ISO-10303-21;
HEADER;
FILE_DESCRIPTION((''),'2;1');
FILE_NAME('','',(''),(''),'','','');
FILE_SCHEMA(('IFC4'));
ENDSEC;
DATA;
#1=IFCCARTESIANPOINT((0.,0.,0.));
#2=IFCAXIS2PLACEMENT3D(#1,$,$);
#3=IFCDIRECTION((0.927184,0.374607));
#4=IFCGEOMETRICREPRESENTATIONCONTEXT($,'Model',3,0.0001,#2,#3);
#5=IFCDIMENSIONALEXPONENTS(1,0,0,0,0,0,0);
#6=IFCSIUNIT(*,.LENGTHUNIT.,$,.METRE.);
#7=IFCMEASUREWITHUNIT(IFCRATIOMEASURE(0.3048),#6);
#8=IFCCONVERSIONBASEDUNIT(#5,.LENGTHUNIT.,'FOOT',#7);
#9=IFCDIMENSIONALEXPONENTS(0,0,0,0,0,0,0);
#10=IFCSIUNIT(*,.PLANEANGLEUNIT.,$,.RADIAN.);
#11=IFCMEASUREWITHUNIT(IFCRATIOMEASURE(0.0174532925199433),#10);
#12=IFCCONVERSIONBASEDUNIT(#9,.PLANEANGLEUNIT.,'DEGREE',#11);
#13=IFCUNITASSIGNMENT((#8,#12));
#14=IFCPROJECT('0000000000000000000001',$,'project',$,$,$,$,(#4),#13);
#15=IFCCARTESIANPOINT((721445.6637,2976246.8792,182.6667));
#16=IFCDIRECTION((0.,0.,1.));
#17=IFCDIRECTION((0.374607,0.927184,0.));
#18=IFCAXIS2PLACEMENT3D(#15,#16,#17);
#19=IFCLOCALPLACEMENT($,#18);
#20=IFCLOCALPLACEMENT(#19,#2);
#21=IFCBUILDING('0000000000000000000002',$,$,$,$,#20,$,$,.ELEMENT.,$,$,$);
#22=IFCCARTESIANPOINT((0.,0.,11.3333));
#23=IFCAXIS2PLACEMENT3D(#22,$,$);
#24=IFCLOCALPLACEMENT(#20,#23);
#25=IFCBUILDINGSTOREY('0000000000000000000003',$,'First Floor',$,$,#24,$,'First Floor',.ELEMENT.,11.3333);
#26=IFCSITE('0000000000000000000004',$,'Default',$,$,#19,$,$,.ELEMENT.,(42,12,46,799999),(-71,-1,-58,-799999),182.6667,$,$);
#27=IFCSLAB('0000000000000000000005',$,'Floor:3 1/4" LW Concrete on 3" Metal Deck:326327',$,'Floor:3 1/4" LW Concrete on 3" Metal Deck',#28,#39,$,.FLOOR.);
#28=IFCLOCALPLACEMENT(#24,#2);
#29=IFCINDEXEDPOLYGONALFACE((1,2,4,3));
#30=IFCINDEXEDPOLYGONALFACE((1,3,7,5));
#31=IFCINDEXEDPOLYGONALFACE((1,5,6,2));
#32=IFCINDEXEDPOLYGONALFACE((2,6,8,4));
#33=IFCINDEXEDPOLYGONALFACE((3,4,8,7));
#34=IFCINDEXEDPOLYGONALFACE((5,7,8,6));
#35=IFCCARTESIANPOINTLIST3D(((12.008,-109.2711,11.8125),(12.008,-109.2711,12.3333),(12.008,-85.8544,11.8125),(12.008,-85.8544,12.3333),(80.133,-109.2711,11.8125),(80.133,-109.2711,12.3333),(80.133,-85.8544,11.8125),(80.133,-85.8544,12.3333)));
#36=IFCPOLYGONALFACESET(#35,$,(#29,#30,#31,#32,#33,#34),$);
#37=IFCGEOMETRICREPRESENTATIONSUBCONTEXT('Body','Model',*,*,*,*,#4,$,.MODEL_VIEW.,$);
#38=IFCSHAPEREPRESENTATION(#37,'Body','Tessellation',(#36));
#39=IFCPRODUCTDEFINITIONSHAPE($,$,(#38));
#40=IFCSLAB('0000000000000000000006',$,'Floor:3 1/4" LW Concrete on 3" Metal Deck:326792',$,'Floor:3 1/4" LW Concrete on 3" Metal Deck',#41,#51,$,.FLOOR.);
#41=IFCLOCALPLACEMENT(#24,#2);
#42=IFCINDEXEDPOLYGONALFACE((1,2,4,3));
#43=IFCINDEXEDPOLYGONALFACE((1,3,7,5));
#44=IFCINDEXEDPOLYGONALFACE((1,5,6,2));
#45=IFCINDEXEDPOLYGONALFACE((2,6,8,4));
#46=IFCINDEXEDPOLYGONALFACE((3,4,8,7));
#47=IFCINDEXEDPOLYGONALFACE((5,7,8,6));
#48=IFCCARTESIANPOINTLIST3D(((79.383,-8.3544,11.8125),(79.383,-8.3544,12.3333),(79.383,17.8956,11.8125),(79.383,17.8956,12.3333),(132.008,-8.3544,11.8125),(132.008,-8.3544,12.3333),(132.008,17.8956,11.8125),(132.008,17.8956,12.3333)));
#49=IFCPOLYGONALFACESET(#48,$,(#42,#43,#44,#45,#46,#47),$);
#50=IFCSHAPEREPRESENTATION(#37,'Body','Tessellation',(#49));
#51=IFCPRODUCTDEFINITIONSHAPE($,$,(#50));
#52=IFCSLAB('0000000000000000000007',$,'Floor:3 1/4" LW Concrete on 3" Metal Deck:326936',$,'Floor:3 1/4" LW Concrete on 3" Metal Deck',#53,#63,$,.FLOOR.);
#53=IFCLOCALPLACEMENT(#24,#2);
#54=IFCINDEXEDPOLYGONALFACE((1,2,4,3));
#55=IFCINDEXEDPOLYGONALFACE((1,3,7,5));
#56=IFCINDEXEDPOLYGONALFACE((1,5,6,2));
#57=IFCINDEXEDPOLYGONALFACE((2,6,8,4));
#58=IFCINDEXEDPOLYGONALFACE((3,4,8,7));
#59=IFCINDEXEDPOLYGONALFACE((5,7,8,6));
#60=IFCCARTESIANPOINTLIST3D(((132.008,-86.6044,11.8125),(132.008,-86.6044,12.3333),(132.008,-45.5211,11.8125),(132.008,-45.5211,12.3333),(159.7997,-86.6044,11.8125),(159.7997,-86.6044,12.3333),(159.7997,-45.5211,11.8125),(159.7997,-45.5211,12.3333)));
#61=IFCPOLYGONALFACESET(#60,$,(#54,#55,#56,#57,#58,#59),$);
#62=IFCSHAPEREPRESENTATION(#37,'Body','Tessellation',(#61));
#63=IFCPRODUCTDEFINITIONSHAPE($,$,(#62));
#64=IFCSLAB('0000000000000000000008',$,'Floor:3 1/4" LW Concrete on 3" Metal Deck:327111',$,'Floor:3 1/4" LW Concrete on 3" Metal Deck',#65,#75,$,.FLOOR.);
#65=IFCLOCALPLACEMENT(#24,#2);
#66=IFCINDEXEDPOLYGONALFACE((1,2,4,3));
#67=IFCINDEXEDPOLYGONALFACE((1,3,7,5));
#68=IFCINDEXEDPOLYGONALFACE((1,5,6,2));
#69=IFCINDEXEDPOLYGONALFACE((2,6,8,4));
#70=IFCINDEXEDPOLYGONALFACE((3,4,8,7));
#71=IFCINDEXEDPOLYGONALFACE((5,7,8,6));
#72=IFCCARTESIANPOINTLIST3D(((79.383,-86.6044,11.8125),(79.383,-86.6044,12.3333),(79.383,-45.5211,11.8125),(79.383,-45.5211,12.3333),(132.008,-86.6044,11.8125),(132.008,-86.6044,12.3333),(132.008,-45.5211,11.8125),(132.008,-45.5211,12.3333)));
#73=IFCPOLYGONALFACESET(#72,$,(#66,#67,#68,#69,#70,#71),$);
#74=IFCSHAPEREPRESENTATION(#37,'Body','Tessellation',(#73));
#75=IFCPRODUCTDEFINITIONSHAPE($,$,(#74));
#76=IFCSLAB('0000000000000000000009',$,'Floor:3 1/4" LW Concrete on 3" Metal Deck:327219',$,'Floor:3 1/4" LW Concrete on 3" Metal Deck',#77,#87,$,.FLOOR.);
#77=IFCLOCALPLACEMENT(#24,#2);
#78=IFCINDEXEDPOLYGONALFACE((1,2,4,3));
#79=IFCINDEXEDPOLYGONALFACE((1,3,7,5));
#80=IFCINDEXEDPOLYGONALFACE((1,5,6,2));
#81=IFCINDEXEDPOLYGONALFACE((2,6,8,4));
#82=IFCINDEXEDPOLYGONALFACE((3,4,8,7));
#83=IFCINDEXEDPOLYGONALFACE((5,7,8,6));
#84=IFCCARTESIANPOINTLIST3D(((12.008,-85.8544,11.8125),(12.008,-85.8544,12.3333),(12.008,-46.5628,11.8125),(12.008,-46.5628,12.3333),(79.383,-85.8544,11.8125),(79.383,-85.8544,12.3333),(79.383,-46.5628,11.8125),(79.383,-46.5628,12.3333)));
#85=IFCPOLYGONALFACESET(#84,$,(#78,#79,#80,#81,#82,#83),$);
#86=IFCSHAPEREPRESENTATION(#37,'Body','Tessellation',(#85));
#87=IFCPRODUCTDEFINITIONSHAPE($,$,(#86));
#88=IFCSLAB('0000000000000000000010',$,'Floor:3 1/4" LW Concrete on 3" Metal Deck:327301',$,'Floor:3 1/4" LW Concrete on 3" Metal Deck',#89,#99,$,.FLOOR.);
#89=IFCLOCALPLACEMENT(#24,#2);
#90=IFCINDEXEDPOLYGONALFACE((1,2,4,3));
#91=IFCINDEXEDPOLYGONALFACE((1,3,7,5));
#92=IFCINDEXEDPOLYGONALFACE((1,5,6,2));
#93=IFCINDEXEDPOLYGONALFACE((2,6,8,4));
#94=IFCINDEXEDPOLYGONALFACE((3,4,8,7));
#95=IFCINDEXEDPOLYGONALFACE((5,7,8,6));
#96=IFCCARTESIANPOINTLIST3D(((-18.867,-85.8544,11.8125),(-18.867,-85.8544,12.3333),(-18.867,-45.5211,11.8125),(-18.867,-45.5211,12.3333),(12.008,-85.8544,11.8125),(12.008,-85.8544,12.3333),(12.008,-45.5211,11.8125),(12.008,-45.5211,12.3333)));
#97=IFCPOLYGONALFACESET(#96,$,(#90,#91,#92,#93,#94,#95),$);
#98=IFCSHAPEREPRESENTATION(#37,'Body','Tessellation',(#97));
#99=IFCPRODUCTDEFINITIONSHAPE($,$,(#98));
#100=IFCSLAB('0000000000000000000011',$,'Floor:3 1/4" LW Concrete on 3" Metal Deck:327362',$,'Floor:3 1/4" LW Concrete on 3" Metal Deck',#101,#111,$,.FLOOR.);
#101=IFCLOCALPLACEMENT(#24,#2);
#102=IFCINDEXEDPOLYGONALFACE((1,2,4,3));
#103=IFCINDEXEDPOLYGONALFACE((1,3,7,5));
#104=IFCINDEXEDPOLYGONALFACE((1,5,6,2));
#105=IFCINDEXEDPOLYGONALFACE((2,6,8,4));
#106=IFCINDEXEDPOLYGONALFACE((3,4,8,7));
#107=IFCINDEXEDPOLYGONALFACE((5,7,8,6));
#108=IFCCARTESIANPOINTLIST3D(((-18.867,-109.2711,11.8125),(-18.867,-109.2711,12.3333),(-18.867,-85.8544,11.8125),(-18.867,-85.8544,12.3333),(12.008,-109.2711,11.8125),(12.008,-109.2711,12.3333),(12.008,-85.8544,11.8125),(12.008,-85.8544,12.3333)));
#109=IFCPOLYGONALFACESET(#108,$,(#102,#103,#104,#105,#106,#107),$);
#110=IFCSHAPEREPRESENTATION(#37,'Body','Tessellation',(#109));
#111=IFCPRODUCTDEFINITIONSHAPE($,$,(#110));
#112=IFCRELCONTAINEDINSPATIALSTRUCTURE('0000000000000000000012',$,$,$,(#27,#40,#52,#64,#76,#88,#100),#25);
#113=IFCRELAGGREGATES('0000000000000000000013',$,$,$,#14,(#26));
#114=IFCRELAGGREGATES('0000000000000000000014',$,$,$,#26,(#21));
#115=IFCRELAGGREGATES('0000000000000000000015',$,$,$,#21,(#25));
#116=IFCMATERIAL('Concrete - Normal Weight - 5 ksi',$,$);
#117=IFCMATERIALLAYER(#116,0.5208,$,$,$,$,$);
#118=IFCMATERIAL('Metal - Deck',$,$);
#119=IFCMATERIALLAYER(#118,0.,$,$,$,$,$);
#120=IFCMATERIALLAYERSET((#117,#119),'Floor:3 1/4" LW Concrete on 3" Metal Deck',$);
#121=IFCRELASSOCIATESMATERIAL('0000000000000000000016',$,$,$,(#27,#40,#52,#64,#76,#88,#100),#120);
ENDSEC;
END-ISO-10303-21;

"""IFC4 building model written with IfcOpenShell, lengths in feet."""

from ifc_helpers import new_model, entity, si_unit, converted_unit, direction, frame, frame_2d, origin, place, context, subcontext, project, spatial, rectangle, extrude, material, layer, layer_set, layer_usage, element, save


model = new_model("IFC4")

# Units and contexts
model_context = context("Model", 3, precision=0.0001, world=origin(), true_north=direction((0.927184, 0.374607)))
body_context = subcontext(model_context, "Body", "Model", "MODEL_VIEW")
ifc_project = project(units=[converted_unit("LENGTHUNIT", "FOOT", entity("IfcRatioMeasure", 0.3048), si_unit("LENGTHUNIT", "METRE"), dimensions=[1, 0, 0, 0, 0, 0, 0]), converted_unit("PLANEANGLEUNIT", "DEGREE", entity("IfcRatioMeasure", 0.0174532925199433), si_unit("PLANEANGLEUNIT", "RADIAN"), dimensions=[0, 0, 0, 0, 0, 0, 0])], contexts=[model_context])

# Site, building, storey
site_placement = place(None, frame((721445.6637, 2976246.8792, 182.6667), z_axis=(0.0, 0.0, 1.0), x_axis=(0.374607, 0.927184, 0.0)))
site = spatial("IfcSite", under=ifc_project, at=site_placement, Name="Default", CompositionType="ELEMENT", RefLatitude=(42, 12, 46, 799999), RefLongitude=(-71, -1, -58, -799999), RefElevation=182.6667)
building_placement = place(site_placement, origin())
building = spatial("IfcBuilding", under=site, at=building_placement, CompositionType="ELEMENT")
storey_placement = place(building_placement, frame((0.0, 0.0, 11.3333)))
storey = spatial("IfcBuildingStorey", under=building, at=storey_placement, Name="First Floor", LongName="First Floor", CompositionType="ELEMENT", Elevation=11.3333)

# Slabs
ifc_material_1 = material(Name="Concrete - Normal Weight - 5 ksi")
ifc_layer_1 = layer(ifc_material_1, 0.5208)
ifc_material_2 = material(Name="Metal - Deck")
ifc_layer_2 = layer(ifc_material_2, 0.0)
ifc_layer_set = layer_set([ifc_layer_1, ifc_layer_2], Name="Floor:3 1/4\" LW Concrete on 3\" Metal Deck")
ifc_layer_usage_1 = layer_usage(ifc_layer_set, "AXIS3", "POSITIVE", 0.0)
slab_1_placement = place(storey_placement, origin())
element("IfcSlab", 1, at=slab_1_placement, inside=storey, material=ifc_layer_usage_1, Name="Floor:3 1/4\" LW Concrete on 3\" Metal Deck:326327", ObjectType="Floor:3 1/4\" LW Concrete on 3\" Metal Deck", PredefinedType="FLOOR", context=body_context, shape_type="SweptSolid", body=[
    extrude(rectangle(XDim=23.4167, YDim=68.125, at=frame_2d((0.0, 0.0), x_axis=(1.0, 0.0))), frame((46.0705, -97.5628, 12.3333), z_axis=(0.0, 0.0, -1.0), x_axis=(0.0, 1.0, 0.0)), (0.0, 0.0, 1.0), 0.5208),
])
ifc_layer_usage_2 = layer_usage(ifc_layer_set, "AXIS3", "POSITIVE", 0.0)
slab_2_placement = place(storey_placement, origin())
element("IfcSlab", 2, at=slab_2_placement, inside=storey, material=ifc_layer_usage_2, Name="Floor:3 1/4\" LW Concrete on 3\" Metal Deck:326792", ObjectType="Floor:3 1/4\" LW Concrete on 3\" Metal Deck", PredefinedType="FLOOR", context=body_context, shape_type="SweptSolid", body=[
    extrude(rectangle(XDim=26.25, YDim=52.625, at=frame_2d((0.0, 0.0), x_axis=(1.0, 0.0))), frame((105.6955, 4.7706, 12.3333), z_axis=(0.0, 0.0, -1.0), x_axis=(0.0, 1.0, 0.0)), (0.0, 0.0, 1.0), 0.5208),
])
ifc_layer_usage_3 = layer_usage(ifc_layer_set, "AXIS3", "POSITIVE", 0.0)
slab_3_placement = place(storey_placement, origin())
element("IfcSlab", 3, at=slab_3_placement, inside=storey, material=ifc_layer_usage_3, Name="Floor:3 1/4\" LW Concrete on 3\" Metal Deck:326936", ObjectType="Floor:3 1/4\" LW Concrete on 3\" Metal Deck", PredefinedType="FLOOR", context=body_context, shape_type="SweptSolid", body=[
    extrude(rectangle(XDim=41.0833, YDim=27.7917, at=frame_2d((0.0, 0.0), x_axis=(1.0, 0.0))), frame((145.9038, -66.0628, 12.3333), z_axis=(0.0, 0.0, -1.0), x_axis=(0.0, 1.0, 0.0)), (0.0, 0.0, 1.0), 0.5208),
])
ifc_layer_usage_4 = layer_usage(ifc_layer_set, "AXIS3", "POSITIVE", 0.0)
slab_4_placement = place(storey_placement, origin())
element("IfcSlab", 4, at=slab_4_placement, inside=storey, material=ifc_layer_usage_4, Name="Floor:3 1/4\" LW Concrete on 3\" Metal Deck:327111", ObjectType="Floor:3 1/4\" LW Concrete on 3\" Metal Deck", PredefinedType="FLOOR", context=body_context, shape_type="SweptSolid", body=[
    extrude(rectangle(XDim=41.0833, YDim=52.625, at=frame_2d((0.0, 0.0), x_axis=(1.0, 0.0))), frame((105.6955, -66.0628, 12.3333), z_axis=(0.0, 0.0, -1.0), x_axis=(0.0, 1.0, 0.0)), (0.0, 0.0, 1.0), 0.5208),
])
ifc_layer_usage_5 = layer_usage(ifc_layer_set, "AXIS3", "POSITIVE", 0.0)
slab_5_placement = place(storey_placement, origin())
element("IfcSlab", 5, at=slab_5_placement, inside=storey, material=ifc_layer_usage_5, Name="Floor:3 1/4\" LW Concrete on 3\" Metal Deck:327219", ObjectType="Floor:3 1/4\" LW Concrete on 3\" Metal Deck", PredefinedType="FLOOR", context=body_context, shape_type="SweptSolid", body=[
    extrude(rectangle(XDim=39.2917, YDim=67.375, at=frame_2d((0.0, 0.0), x_axis=(1.0, 0.0))), frame((45.6955, -66.2086, 12.3333), z_axis=(0.0, 0.0, -1.0), x_axis=(0.0, 1.0, 0.0)), (0.0, 0.0, 1.0), 0.5208),
])
ifc_layer_usage_6 = layer_usage(ifc_layer_set, "AXIS3", "POSITIVE", 0.0)
slab_6_placement = place(storey_placement, origin())
element("IfcSlab", 6, at=slab_6_placement, inside=storey, material=ifc_layer_usage_6, Name="Floor:3 1/4\" LW Concrete on 3\" Metal Deck:327301", ObjectType="Floor:3 1/4\" LW Concrete on 3\" Metal Deck", PredefinedType="FLOOR", context=body_context, shape_type="SweptSolid", body=[
    extrude(rectangle(XDim=40.3333, YDim=30.875, at=frame_2d((0.0, 0.0), x_axis=(1.0, 0.0))), frame((-3.4295, -65.6878, 12.3333), z_axis=(0.0, 0.0, -1.0), x_axis=(0.0, 1.0, 0.0)), (0.0, 0.0, 1.0), 0.5208),
])
ifc_layer_usage_7 = layer_usage(ifc_layer_set, "AXIS3", "POSITIVE", 0.0)
slab_7_placement = place(storey_placement, origin())
element("IfcSlab", 7, at=slab_7_placement, inside=storey, material=ifc_layer_usage_7, Name="Floor:3 1/4\" LW Concrete on 3\" Metal Deck:327362", ObjectType="Floor:3 1/4\" LW Concrete on 3\" Metal Deck", PredefinedType="FLOOR", context=body_context, shape_type="SweptSolid", body=[
    extrude(rectangle(XDim=23.4167, YDim=30.875, at=frame_2d((0.0, 0.0), x_axis=(1.0, 0.0))), frame((-3.4295, -97.5628, 12.3333), z_axis=(0.0, 0.0, -1.0), x_axis=(0.0, 1.0, 0.0)), (0.0, 0.0, 1.0), 0.5208),
])

save(model, "model.ifc")
